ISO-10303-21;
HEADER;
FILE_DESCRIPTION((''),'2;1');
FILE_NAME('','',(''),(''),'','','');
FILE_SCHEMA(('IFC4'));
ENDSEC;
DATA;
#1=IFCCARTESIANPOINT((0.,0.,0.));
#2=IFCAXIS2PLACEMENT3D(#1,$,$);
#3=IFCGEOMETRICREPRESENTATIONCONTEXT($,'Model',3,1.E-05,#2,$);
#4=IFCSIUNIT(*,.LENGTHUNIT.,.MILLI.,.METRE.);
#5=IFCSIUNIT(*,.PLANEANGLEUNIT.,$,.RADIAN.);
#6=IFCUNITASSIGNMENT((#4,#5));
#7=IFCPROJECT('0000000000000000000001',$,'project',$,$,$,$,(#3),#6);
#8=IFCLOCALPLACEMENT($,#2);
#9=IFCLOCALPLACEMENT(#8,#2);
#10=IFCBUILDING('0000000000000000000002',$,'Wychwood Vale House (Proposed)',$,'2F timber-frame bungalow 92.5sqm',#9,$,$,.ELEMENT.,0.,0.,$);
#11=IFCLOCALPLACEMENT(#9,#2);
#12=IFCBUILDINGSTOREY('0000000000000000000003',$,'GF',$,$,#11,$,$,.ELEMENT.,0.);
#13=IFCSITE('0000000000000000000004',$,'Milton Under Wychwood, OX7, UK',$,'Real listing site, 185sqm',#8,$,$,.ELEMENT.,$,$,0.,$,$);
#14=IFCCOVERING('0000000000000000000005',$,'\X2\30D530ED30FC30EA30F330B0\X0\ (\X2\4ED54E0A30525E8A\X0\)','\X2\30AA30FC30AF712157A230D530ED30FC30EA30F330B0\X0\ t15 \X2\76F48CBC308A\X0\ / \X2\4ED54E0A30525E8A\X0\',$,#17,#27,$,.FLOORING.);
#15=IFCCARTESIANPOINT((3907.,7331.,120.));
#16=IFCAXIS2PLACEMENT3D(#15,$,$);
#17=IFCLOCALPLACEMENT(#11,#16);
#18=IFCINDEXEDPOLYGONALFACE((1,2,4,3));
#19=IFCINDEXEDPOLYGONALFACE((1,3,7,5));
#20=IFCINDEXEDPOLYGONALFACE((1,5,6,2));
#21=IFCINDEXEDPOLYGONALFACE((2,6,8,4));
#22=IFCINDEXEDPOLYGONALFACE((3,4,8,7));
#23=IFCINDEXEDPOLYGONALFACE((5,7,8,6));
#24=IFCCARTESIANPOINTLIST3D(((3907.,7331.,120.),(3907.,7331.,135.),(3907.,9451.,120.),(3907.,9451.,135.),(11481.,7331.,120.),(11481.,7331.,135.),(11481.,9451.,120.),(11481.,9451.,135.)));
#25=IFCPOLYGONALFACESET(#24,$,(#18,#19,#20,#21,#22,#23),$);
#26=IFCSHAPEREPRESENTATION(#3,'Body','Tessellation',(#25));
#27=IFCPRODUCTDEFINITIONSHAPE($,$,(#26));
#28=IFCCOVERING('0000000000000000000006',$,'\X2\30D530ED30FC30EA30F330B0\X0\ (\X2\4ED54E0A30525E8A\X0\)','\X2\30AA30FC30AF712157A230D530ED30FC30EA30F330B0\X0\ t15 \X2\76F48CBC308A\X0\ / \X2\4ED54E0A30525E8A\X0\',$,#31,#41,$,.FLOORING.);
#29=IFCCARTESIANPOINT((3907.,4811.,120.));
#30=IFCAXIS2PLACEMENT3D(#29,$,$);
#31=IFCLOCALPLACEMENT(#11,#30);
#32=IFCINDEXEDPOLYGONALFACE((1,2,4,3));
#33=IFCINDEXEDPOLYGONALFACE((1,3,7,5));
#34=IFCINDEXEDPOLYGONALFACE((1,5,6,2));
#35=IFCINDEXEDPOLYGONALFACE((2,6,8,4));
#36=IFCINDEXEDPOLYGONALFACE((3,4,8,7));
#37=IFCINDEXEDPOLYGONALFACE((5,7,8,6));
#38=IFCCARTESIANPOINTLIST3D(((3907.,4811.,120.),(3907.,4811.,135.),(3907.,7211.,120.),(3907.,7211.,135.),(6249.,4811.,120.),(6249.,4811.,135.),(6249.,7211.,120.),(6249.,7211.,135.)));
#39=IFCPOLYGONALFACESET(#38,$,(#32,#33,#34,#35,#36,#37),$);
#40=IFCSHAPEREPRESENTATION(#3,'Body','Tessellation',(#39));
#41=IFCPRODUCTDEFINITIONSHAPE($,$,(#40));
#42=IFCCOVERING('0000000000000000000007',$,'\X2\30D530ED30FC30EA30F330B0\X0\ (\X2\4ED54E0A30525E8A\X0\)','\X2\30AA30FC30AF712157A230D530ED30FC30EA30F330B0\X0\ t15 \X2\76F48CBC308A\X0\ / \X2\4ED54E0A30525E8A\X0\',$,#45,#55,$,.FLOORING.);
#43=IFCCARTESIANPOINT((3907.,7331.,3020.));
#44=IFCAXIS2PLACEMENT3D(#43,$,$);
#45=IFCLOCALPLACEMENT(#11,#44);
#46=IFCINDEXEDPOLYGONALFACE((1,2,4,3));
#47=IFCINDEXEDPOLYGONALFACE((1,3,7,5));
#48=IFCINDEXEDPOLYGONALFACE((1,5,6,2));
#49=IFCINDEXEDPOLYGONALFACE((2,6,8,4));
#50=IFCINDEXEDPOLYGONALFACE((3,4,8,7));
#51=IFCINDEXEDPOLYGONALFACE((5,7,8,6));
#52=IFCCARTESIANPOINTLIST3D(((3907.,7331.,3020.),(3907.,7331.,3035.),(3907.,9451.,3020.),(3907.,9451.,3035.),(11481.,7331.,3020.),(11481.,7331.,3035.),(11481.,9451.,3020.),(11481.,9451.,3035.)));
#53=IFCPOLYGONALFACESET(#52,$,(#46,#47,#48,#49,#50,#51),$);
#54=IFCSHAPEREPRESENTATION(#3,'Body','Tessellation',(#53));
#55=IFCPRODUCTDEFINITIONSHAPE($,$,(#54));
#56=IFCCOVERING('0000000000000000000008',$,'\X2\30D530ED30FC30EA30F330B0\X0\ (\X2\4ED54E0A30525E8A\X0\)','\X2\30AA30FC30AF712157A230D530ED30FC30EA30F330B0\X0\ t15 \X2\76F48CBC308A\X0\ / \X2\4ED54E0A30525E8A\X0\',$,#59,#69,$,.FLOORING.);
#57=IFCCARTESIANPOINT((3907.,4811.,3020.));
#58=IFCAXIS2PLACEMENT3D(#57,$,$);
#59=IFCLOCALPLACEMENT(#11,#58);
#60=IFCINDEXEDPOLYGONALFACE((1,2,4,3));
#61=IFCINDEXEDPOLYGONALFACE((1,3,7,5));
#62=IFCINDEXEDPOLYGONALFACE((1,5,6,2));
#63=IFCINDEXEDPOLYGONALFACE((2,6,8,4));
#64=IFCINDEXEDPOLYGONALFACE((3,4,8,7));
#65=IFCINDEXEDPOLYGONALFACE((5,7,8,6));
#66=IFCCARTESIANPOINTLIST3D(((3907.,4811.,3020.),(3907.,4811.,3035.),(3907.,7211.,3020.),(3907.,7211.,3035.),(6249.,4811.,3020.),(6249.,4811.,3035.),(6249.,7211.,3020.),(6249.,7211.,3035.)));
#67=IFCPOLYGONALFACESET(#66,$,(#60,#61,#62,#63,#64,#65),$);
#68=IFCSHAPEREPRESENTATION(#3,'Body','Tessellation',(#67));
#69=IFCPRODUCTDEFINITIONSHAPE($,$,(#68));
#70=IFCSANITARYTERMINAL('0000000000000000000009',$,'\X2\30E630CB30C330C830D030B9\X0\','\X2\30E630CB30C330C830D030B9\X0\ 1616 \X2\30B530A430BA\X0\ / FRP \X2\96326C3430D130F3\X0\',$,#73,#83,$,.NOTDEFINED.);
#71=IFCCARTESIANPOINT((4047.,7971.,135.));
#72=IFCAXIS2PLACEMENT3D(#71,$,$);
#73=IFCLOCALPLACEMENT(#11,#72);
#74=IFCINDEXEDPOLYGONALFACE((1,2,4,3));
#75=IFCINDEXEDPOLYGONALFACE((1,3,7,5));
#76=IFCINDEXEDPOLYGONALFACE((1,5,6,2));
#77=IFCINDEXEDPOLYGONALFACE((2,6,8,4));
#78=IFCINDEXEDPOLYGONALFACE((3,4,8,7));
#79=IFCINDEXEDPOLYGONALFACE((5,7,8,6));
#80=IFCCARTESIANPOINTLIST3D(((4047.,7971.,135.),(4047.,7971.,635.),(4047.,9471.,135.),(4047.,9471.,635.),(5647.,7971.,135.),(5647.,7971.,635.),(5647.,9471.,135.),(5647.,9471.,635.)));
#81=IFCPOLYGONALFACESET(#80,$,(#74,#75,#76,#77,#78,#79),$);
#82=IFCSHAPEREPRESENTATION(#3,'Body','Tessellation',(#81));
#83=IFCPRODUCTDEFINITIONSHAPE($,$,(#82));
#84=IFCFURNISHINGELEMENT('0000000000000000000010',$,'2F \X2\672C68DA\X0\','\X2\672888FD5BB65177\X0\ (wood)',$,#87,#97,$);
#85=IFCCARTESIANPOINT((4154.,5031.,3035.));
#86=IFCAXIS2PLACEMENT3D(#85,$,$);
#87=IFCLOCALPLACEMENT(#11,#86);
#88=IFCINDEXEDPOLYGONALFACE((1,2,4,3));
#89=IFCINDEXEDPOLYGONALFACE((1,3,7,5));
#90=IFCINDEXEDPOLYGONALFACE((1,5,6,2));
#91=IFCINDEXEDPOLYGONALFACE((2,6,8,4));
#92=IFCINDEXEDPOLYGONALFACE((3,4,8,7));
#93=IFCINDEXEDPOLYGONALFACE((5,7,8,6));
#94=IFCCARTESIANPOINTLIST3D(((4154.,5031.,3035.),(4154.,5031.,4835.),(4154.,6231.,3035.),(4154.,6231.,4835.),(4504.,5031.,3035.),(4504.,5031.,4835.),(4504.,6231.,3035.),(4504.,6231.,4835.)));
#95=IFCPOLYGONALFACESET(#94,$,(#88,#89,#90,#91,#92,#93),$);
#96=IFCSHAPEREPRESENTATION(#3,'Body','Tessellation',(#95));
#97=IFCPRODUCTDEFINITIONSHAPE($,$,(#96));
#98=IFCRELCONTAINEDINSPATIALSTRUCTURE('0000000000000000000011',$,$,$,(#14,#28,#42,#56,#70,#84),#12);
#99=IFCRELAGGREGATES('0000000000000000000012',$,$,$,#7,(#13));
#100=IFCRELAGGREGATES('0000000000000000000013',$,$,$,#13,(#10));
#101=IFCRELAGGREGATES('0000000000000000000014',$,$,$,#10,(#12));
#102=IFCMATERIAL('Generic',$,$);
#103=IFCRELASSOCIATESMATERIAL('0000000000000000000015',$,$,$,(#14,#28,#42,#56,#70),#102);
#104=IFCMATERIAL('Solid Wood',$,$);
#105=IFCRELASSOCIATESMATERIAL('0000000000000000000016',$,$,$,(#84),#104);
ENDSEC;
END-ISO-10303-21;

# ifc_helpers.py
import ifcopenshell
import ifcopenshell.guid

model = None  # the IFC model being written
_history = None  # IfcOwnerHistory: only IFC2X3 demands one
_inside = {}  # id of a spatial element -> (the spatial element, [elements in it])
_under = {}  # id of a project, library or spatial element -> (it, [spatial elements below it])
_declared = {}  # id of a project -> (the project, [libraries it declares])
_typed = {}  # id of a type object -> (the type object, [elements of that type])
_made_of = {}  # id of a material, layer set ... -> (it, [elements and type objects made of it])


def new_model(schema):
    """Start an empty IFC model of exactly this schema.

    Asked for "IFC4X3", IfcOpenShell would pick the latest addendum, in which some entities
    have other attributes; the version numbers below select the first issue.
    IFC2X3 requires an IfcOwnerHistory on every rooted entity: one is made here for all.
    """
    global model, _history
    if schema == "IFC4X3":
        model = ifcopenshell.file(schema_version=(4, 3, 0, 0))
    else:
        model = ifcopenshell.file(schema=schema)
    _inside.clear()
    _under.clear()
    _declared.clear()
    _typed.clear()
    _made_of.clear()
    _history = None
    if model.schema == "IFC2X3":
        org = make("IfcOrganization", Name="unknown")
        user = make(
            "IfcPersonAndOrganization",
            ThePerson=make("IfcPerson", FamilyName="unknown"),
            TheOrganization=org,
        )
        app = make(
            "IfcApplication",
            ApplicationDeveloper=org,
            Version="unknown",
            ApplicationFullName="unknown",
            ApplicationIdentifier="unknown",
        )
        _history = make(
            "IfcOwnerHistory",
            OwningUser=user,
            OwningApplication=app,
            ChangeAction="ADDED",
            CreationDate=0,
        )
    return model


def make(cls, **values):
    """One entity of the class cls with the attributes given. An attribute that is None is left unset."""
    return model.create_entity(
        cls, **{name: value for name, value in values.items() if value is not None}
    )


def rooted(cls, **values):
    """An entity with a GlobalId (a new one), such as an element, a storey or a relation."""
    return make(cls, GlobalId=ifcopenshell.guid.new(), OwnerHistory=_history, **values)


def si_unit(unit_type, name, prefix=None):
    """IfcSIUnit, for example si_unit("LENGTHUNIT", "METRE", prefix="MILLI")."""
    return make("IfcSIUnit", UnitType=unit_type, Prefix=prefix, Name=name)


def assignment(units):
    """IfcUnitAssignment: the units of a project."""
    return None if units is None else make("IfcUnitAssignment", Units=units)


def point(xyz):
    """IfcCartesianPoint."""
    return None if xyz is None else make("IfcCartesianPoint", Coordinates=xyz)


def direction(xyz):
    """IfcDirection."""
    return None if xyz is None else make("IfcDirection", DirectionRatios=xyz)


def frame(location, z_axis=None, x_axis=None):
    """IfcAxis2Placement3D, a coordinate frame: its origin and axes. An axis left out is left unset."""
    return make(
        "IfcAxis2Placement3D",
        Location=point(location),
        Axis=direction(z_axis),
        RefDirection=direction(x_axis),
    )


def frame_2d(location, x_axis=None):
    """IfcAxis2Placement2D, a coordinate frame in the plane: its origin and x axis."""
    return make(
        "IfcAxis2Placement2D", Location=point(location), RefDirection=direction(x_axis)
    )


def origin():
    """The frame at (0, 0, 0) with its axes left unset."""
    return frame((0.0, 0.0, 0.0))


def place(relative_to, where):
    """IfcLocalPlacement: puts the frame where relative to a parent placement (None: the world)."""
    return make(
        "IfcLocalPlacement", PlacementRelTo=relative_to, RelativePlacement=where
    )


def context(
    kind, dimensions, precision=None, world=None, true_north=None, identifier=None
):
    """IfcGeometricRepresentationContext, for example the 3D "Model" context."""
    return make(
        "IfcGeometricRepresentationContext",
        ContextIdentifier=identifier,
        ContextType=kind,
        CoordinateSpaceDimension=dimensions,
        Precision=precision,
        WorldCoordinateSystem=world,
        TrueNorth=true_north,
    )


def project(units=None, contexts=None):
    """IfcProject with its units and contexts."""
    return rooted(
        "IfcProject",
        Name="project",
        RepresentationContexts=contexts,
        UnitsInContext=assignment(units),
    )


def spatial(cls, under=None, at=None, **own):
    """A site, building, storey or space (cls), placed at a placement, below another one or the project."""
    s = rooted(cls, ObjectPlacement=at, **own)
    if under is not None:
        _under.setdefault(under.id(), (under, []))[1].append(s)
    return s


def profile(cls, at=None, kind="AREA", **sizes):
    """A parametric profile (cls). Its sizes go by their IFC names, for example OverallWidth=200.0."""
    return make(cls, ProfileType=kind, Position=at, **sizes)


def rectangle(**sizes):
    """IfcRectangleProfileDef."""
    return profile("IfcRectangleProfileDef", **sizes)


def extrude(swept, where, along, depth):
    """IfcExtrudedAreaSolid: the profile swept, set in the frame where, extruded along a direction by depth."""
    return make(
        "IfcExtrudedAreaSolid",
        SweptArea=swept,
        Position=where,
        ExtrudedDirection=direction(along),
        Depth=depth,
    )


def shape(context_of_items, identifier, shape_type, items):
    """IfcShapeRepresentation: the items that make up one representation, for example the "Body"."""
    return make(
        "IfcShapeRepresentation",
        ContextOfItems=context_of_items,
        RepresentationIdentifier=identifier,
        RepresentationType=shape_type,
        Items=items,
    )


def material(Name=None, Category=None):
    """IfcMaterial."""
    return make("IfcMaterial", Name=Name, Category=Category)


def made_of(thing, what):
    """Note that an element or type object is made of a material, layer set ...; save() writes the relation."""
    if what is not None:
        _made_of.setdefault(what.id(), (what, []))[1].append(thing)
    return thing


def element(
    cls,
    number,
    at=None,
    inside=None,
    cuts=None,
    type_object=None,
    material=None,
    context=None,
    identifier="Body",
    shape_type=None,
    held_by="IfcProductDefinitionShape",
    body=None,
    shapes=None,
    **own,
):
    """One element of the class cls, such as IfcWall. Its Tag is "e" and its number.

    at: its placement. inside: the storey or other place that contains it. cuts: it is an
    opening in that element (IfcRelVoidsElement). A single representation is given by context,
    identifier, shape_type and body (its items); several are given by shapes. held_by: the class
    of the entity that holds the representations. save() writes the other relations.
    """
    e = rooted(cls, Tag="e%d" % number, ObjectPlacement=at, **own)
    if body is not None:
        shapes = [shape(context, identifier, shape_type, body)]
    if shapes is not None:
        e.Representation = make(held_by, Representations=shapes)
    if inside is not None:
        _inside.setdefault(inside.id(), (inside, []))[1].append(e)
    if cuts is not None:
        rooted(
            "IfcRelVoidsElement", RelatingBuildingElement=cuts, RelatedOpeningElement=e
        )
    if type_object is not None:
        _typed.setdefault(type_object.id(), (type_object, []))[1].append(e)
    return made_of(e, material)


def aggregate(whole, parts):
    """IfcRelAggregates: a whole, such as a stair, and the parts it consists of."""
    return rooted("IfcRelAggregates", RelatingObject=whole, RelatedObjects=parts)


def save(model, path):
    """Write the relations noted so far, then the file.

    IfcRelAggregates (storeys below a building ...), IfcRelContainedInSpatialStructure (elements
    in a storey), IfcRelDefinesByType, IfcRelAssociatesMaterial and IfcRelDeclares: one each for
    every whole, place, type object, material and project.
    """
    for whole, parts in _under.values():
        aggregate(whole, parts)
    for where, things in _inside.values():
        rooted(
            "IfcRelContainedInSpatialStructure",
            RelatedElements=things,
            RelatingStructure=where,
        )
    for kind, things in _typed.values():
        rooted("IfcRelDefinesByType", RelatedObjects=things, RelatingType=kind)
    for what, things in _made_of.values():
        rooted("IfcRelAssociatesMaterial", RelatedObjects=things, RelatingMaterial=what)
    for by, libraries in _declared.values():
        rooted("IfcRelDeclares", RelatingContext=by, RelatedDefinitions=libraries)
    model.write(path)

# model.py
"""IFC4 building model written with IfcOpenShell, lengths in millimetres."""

from ifc_helpers import new_model, si_unit, frame, frame_2d, origin, place, context, project, spatial, rectangle, extrude, material, element, save


model = new_model("IFC4")

# Units and contexts
model_context = context("Model", 3, precision=1e-05, world=origin())
ifc_project = project(units=[si_unit("LENGTHUNIT", "METRE", prefix="MILLI"), si_unit("PLANEANGLEUNIT", "RADIAN")], contexts=[model_context])

# Site, building, storey
site_placement = place(None, origin())
site = spatial("IfcSite", under=ifc_project, at=site_placement, Name="Milton Under Wychwood, OX7, UK", ObjectType="Real listing site, 185sqm", CompositionType="ELEMENT", RefElevation=0.0)
building_placement = place(site_placement, origin())
building = spatial("IfcBuilding", under=site, at=building_placement, Name="Wychwood Vale House (Proposed)", ObjectType="2F timber-frame bungalow 92.5sqm", CompositionType="ELEMENT", ElevationOfRefHeight=0.0, ElevationOfTerrain=0.0)
storey_placement = place(building_placement, origin())
storey = spatial("IfcBuildingStorey", under=building, at=storey_placement, Name="GF", CompositionType="ELEMENT", Elevation=0.0)

# Shared definitions
ifc_material_1 = material(Name="Solid Wood")

# Coverings
ifc_material_2 = material(Name="Generic")
covering_1_placement = place(storey_placement, frame((3907.0, 7331.0, 120.0)))
element("IfcCovering", 1, at=covering_1_placement, inside=storey, material=ifc_material_2, Name="フローリング (仕上げ床)", Description="オーク無垢フローリング t15 直貼り / 仕上げ床", PredefinedType="FLOORING", context=model_context, shape_type="SweptSolid", body=[
    extrude(rectangle(XDim=7574.0, YDim=2120.0, at=frame_2d((3787.0, 1060.0))), frame((3907.0, 7331.0, 120.0)), (0.0, 0.0, 1.0), 15.0),
])
covering_2_placement = place(storey_placement, frame((3907.0, 4811.0, 120.0)))
element("IfcCovering", 2, at=covering_2_placement, inside=storey, material=ifc_material_2, Name="フローリング (仕上げ床)", Description="オーク無垢フローリング t15 直貼り / 仕上げ床", PredefinedType="FLOORING", context=model_context, shape_type="SweptSolid", body=[
    extrude(rectangle(XDim=2342.0, YDim=2400.0, at=frame_2d((1171.0, 1200.0))), frame((3907.0, 4811.0, 120.0)), (0.0, 0.0, 1.0), 15.0),
])
covering_3_placement = place(storey_placement, frame((3907.0, 7331.0, 3020.0)))
element("IfcCovering", 3, at=covering_3_placement, inside=storey, material=ifc_material_2, Name="フローリング (仕上げ床)", Description="オーク無垢フローリング t15 直貼り / 仕上げ床", PredefinedType="FLOORING", context=model_context, shape_type="SweptSolid", body=[
    extrude(rectangle(XDim=7574.0, YDim=2120.0, at=frame_2d((3787.0, 1060.0))), frame((3907.0, 7331.0, 3020.0)), (0.0, 0.0, 1.0), 15.0),
])
covering_4_placement = place(storey_placement, frame((3907.0, 4811.0, 3020.0)))
element("IfcCovering", 4, at=covering_4_placement, inside=storey, material=ifc_material_2, Name="フローリング (仕上げ床)", Description="オーク無垢フローリング t15 直貼り / 仕上げ床", PredefinedType="FLOORING", context=model_context, shape_type="SweptSolid", body=[
    extrude(rectangle(XDim=2342.0, YDim=2400.0, at=frame_2d((1171.0, 1200.0))), frame((3907.0, 4811.0, 3020.0)), (0.0, 0.0, 1.0), 15.0),
])

# Sanitary terminal
sanitary_terminal_placement = place(storey_placement, frame((4047.0, 7971.0, 135.0)))
element("IfcSanitaryTerminal", 5, at=sanitary_terminal_placement, inside=storey, material=ifc_material_2, Name="ユニットバス", Description="ユニットバス 1616 サイズ / FRP 防水パン", PredefinedType="NOTDEFINED", context=model_context, shape_type="SweptSolid", body=[
    extrude(rectangle(XDim=1600.0, YDim=1500.0, at=frame_2d((800.0, 750.0))), frame((4047.0, 7971.0, 135.0)), (0.0, 0.0, 1.0), 500.0),
])

# Furnishing element
furnishing_placement = place(storey_placement, frame((4154.0, 5031.0, 3035.0)))
element("IfcFurnishingElement", 6, at=furnishing_placement, inside=storey, material=ifc_material_1, Name="2F 本棚", Description="木製家具 (wood)", context=model_context, shape_type="SweptSolid", body=[
    extrude(rectangle(XDim=350.0, YDim=1200.0, at=frame_2d((175.0, 600.0))), frame((4154.0, 5031.0, 3035.0)), (0.0, 0.0, 1.0), 1800.0),
])

save(model, "model.ifc")
